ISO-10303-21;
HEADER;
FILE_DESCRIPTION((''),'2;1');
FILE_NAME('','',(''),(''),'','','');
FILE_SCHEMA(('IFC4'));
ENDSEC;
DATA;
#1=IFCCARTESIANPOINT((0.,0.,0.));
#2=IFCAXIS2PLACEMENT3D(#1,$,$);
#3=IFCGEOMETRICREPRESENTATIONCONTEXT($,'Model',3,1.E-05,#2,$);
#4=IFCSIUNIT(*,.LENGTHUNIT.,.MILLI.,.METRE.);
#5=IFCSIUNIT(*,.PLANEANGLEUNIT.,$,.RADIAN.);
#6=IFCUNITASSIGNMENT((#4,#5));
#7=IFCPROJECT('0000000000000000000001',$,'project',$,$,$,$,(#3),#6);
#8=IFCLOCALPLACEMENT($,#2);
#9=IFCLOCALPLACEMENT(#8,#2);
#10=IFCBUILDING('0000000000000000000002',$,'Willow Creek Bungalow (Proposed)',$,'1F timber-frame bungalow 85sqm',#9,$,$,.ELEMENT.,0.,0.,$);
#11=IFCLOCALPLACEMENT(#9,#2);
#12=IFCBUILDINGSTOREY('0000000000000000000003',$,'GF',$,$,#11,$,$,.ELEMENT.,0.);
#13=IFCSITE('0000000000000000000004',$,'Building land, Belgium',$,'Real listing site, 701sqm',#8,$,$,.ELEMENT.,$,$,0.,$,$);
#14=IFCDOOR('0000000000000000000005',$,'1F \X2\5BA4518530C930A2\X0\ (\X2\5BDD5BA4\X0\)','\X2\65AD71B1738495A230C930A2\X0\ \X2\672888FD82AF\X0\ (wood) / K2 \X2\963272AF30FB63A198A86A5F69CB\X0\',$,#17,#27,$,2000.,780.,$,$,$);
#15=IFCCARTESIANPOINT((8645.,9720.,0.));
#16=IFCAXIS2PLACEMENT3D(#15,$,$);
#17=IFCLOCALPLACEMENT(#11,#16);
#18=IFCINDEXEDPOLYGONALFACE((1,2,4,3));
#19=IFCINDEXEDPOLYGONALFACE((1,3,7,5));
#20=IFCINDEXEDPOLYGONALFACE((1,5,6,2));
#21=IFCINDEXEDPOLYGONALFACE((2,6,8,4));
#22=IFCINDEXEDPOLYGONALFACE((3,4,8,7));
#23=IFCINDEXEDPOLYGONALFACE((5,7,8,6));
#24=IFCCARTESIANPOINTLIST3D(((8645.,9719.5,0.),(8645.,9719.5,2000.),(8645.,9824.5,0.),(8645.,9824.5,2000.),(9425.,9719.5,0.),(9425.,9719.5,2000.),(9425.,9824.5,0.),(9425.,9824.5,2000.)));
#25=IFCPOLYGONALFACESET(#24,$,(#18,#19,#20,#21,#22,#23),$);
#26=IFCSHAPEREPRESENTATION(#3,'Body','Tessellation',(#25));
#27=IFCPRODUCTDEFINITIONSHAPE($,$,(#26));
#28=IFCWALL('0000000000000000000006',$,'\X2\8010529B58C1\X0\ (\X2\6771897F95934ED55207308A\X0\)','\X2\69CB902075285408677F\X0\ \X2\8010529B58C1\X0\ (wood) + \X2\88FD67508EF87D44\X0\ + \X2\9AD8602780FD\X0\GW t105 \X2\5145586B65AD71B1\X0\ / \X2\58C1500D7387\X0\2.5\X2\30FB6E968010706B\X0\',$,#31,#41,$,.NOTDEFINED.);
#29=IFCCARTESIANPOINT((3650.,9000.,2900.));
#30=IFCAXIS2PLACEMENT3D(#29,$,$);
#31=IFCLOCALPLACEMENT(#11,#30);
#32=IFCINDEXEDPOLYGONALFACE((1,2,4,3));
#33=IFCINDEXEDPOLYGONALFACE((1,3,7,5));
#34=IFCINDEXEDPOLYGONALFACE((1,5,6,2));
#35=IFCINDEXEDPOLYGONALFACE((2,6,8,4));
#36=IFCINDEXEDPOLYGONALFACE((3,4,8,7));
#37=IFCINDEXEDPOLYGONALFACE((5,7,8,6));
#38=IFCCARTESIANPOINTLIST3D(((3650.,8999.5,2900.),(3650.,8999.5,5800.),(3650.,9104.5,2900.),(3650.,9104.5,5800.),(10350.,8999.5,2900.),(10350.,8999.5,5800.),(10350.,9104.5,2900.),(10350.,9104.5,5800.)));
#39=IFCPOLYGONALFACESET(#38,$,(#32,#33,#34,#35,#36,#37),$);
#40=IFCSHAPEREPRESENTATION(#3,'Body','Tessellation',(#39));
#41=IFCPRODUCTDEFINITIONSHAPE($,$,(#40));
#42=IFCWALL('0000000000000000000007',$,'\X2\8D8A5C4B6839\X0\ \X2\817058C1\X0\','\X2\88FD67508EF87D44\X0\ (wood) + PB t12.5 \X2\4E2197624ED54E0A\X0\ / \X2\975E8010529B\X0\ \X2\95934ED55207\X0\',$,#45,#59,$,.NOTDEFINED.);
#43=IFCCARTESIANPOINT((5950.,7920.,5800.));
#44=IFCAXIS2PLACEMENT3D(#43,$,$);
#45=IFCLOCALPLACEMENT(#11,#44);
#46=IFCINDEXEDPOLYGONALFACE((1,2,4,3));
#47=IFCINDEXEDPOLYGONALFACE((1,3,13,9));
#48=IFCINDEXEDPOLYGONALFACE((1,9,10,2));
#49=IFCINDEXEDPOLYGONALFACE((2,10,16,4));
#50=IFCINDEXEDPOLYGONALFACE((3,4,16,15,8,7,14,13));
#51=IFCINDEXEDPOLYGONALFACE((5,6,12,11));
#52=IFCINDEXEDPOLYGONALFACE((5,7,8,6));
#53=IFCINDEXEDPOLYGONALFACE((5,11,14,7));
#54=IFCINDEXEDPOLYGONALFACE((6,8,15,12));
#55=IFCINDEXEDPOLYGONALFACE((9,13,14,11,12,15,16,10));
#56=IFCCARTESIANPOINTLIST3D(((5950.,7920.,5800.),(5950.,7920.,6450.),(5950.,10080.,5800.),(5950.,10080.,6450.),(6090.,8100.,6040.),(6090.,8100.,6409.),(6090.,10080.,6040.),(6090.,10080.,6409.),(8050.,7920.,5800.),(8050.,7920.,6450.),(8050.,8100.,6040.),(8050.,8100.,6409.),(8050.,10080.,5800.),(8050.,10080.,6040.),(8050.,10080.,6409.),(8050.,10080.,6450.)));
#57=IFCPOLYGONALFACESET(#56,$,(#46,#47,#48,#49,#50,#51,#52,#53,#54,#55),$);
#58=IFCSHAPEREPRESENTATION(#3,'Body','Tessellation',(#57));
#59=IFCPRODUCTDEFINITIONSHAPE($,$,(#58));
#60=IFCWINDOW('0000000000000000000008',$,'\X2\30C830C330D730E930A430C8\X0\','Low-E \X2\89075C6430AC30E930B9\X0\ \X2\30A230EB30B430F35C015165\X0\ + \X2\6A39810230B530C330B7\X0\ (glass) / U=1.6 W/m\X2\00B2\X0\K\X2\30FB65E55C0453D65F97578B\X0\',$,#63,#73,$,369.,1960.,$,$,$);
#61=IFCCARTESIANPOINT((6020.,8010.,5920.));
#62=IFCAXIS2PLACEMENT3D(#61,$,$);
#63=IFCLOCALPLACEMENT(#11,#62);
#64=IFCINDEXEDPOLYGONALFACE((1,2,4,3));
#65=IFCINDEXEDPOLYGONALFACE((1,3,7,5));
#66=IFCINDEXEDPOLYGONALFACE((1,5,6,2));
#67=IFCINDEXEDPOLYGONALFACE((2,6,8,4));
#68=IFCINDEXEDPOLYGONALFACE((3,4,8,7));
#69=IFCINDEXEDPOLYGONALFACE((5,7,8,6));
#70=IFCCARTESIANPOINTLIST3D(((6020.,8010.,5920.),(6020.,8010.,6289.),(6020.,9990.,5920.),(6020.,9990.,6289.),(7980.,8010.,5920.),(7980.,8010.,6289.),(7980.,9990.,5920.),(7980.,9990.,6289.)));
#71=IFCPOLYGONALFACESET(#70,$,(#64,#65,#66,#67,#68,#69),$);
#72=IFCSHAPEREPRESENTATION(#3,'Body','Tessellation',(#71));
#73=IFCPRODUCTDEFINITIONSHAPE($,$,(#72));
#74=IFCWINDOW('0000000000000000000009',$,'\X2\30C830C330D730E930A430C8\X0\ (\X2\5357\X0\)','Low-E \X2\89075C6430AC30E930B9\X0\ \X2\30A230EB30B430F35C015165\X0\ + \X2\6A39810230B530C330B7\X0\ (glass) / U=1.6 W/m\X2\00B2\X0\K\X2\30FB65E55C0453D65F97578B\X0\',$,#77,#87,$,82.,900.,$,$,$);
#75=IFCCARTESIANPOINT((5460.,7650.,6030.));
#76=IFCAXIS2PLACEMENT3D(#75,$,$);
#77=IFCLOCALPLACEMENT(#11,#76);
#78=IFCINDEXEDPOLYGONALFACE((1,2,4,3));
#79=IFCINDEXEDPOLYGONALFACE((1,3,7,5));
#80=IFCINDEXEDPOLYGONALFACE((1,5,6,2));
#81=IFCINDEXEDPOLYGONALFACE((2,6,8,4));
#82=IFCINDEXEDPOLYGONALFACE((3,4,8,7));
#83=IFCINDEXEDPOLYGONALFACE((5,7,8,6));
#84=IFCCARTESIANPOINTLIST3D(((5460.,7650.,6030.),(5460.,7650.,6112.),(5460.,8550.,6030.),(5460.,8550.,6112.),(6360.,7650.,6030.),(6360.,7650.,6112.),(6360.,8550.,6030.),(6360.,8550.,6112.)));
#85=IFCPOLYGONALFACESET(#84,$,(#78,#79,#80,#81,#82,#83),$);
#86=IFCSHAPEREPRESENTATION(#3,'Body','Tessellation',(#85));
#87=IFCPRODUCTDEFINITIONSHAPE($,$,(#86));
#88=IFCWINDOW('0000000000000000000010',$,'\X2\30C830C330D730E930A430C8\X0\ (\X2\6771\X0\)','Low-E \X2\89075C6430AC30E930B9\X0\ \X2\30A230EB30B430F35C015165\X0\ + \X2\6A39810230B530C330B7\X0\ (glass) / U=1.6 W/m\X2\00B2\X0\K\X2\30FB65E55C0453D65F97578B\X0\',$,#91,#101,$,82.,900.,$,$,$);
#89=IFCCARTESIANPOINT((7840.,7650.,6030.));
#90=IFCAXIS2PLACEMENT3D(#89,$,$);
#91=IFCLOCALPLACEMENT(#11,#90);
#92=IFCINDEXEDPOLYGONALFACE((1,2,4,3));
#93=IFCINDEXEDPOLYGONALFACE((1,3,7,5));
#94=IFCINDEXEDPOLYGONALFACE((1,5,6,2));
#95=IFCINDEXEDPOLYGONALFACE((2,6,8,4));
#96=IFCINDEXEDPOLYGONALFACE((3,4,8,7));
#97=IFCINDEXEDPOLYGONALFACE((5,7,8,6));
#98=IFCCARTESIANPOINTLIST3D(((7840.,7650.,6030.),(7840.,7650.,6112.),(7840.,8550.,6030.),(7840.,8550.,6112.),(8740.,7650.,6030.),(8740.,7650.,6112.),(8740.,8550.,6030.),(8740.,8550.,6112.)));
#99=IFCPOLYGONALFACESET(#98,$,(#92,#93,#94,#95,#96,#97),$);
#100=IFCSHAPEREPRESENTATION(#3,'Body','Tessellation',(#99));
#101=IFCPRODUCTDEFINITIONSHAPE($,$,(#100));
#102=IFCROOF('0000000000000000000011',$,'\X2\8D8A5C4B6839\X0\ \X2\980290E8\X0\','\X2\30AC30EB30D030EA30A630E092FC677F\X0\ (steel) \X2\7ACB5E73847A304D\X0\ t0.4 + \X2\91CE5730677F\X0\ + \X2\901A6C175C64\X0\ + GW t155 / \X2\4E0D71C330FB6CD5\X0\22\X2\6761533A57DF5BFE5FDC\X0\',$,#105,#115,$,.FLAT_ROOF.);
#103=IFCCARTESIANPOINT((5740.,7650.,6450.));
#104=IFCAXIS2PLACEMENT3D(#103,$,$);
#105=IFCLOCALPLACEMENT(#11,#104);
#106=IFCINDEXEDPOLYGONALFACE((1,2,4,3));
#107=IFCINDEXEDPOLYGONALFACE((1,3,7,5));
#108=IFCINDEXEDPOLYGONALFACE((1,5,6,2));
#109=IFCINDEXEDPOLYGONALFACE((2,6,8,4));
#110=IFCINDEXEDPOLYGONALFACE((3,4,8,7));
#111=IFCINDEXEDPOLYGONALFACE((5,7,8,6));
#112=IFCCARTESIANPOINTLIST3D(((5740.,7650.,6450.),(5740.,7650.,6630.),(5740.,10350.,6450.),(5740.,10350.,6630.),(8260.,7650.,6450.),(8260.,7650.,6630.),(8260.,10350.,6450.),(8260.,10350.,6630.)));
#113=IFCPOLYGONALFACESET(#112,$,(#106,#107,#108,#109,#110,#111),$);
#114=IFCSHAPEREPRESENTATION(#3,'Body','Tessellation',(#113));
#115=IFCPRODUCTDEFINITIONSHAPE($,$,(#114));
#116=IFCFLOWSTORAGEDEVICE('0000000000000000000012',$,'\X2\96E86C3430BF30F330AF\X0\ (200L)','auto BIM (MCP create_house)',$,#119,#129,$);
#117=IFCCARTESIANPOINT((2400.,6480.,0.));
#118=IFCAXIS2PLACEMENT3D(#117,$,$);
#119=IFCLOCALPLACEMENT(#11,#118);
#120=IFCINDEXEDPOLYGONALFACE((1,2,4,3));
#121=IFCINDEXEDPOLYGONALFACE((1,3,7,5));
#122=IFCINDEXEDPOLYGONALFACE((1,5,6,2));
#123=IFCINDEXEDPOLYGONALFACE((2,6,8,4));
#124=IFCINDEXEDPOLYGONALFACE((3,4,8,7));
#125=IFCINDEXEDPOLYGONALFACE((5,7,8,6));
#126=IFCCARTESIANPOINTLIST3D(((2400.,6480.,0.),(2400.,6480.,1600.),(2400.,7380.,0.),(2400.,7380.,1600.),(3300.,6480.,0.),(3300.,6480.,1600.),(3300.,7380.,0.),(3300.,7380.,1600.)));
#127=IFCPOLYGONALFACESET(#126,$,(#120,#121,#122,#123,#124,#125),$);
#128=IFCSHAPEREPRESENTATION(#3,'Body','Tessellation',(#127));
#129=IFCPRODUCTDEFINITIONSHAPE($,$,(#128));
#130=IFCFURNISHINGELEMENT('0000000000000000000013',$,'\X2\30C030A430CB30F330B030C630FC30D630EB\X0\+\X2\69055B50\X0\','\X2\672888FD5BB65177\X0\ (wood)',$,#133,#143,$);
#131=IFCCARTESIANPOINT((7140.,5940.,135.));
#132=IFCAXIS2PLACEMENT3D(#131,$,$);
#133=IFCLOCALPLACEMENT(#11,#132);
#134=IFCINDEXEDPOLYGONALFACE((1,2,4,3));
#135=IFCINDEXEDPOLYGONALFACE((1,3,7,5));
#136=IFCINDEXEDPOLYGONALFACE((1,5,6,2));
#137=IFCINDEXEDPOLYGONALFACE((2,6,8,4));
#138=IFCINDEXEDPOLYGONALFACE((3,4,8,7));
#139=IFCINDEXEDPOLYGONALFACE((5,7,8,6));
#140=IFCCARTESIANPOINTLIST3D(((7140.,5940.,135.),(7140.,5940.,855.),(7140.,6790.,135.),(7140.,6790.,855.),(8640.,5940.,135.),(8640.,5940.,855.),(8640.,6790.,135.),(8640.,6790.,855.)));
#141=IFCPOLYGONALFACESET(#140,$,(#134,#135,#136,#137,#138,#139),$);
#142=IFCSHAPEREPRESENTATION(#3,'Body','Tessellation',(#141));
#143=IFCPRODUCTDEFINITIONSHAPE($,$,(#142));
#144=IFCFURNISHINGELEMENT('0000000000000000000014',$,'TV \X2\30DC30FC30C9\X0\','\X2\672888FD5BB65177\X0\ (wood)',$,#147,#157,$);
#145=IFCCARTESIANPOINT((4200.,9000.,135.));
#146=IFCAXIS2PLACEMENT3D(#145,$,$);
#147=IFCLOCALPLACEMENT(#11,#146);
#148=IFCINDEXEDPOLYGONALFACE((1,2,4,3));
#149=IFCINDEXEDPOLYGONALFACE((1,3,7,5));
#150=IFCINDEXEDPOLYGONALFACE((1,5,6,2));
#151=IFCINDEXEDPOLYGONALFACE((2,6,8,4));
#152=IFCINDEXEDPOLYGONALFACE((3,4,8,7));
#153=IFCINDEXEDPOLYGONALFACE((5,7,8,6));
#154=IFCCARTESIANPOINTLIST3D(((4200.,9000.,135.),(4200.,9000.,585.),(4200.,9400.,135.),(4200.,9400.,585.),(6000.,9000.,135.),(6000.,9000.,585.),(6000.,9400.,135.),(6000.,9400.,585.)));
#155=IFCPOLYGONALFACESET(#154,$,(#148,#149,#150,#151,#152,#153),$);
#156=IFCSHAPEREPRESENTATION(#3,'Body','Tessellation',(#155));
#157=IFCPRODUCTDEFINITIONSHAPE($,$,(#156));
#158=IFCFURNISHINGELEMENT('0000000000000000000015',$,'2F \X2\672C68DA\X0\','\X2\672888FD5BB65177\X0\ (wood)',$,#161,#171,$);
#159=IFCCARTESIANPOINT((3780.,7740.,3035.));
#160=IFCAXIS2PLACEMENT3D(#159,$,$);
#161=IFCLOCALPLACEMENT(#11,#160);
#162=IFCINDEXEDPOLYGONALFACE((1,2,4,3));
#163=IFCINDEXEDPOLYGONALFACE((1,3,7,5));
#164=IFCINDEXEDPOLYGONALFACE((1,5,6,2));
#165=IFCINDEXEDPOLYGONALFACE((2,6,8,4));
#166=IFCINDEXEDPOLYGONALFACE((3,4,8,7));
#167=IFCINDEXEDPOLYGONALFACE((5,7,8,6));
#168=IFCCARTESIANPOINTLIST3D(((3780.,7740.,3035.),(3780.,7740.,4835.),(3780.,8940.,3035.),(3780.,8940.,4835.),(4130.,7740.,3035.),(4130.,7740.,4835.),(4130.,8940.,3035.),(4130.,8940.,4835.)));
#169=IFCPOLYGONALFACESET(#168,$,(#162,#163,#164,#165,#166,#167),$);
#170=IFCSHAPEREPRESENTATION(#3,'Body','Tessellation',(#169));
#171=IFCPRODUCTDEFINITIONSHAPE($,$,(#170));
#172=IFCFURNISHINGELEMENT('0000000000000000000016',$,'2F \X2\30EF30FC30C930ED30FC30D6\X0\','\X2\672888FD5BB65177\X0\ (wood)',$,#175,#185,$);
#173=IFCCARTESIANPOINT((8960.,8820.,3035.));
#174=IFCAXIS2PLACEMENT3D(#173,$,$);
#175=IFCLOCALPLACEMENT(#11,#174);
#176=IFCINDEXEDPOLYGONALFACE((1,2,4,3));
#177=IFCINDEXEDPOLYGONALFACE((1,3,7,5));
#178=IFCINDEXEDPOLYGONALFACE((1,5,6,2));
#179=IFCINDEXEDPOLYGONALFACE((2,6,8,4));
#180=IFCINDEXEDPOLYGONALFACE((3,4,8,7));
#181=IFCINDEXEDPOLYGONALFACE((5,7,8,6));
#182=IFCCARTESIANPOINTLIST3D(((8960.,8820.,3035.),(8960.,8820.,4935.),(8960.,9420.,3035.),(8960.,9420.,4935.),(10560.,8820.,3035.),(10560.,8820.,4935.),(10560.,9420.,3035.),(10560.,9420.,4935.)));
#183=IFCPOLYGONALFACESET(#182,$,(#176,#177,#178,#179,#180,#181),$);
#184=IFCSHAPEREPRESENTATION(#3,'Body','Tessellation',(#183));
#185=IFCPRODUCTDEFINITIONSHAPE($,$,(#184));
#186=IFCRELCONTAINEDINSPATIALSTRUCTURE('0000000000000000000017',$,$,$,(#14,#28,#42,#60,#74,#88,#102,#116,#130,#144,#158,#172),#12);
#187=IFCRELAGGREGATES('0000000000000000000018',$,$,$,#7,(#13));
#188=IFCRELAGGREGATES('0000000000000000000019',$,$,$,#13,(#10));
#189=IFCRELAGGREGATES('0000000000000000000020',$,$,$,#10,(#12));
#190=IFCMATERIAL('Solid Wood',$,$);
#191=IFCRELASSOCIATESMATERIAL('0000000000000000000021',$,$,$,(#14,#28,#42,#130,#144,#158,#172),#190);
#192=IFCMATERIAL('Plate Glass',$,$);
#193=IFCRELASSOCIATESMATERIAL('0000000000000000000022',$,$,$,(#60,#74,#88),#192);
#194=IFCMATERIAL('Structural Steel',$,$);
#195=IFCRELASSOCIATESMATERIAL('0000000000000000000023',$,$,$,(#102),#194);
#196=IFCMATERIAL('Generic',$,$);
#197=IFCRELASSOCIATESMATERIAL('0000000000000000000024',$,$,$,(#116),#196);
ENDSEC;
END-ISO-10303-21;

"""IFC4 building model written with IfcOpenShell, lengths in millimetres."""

from ifc_helpers import new_model, si_unit, frame, frame_2d, origin, place, context, project, spatial, rectangle, extrude, material, element, fill, save


model = new_model("IFC4")

# Units and contexts
model_context = context("Model", 3, precision=1e-05, world=origin())
ifc_project = project(units=[si_unit("LENGTHUNIT", "METRE", prefix="MILLI"), si_unit("PLANEANGLEUNIT", "RADIAN")], contexts=[model_context])

# Site, building, storey
site_placement = place(None, origin())
site = spatial("IfcSite", under=ifc_project, at=site_placement, Name="Building land, Belgium", ObjectType="Real listing site, 701sqm", CompositionType="ELEMENT", RefElevation=0.0)
building_placement = place(site_placement, origin())
building = spatial("IfcBuilding", under=site, at=building_placement, Name="Willow Creek Bungalow (Proposed)", ObjectType="1F timber-frame bungalow 85sqm", CompositionType="ELEMENT", ElevationOfRefHeight=0.0, ElevationOfTerrain=0.0)
storey_placement = place(building_placement, origin())
storey = spatial("IfcBuildingStorey", under=building, at=storey_placement, Name="GF", CompositionType="ELEMENT", Elevation=0.0)

# Shared definitions
ifc_material_1 = material(Name="Solid Wood")

# Door
door_placement = place(storey_placement, frame((8645.0, 9720.0, 0.0)))
element("IfcDoor", 1, at=door_placement, inside=storey, material=ifc_material_1, Name="1F 室内ドア (寝室)", Description="断熱玄関ドア 木製芯 (wood) / K2 防犯・採風機構", OverallHeight=2000.0, OverallWidth=780.0, context=model_context, shape_type="SweptSolid", body=[
    extrude(rectangle(XDim=780.0, YDim=105.0, at=frame_2d((390.0, 52.0))), frame((8645.0, 9720.0, 0.0)), (0.0, 0.0, 1.0), 2000.0),
])

# Wall
wall_1_placement = place(storey_placement, frame((3650.0, 9000.0, 2900.0)))
element("IfcWall", 2, at=wall_1_placement, inside=storey, material=ifc_material_1, Name="耐力壁 (東西間仕切り)", Description="構造用合板 耐力壁 (wood) + 製材軸組 + 高性能GW t105 充填断熱 / 壁倍率2.5・準耐火", PredefinedType="NOTDEFINED", context=model_context, shape_type="SweptSolid", body=[
    extrude(rectangle(XDim=6700.0, YDim=105.0, at=frame_2d((3350.0, 52.0))), frame((3650.0, 9000.0, 2900.0)), (0.0, 0.0, 1.0), 2900.0),
])

# Wall, openings, windows
wall_2_placement = place(storey_placement, frame((5950.0, 7920.0, 5800.0)))
wall_2 = element("IfcWall", 3, at=wall_2_placement, inside=storey, material=ifc_material_1, Name="越屋根 腰壁", Description="製材軸組 (wood) + PB t12.5 両面仕上 / 非耐力 間仕切", PredefinedType="NOTDEFINED", context=model_context, shape_type="SweptSolid", body=[
    extrude(rectangle(XDim=2100.0, YDim=2160.0, at=frame_2d((1050.0, 1080.0))), frame((5950.0, 7920.0, 5800.0)), (0.0, 0.0, 1.0), 650.0),
])
opening_1_placement = place(storey_placement, frame((6020.0, 8010.0, 5920.0)))
opening_1 = element("IfcOpeningElement", 4, at=opening_1_placement, cuts=wall_2, PredefinedType="NOTDEFINED", context=model_context, shape_type="SweptSolid", body=[
    extrude(rectangle(XDim=1960.0, YDim=1980.0, at=frame_2d((980.0, 990.0))), frame((6020.0, 8010.0, 5920.0)), (0.0, 0.0, 1.0), 369.0),
])
opening_2_placement = place(storey_placement, frame((5460.0, 7650.0, 6030.0)))
opening_2 = element("IfcOpeningElement", 5, at=opening_2_placement, cuts=wall_2, PredefinedType="NOTDEFINED", context=model_context, shape_type="SweptSolid", body=[
    extrude(rectangle(XDim=900.0, YDim=900.0, at=frame_2d((450.0, 450.0))), frame((5460.0, 7650.0, 6030.0)), (0.0, 0.0, 1.0), 82.0),
])
opening_3_placement = place(storey_placement, frame((7840.0, 7650.0, 6030.0)))
opening_3 = element("IfcOpeningElement", 6, at=opening_3_placement, cuts=wall_2, PredefinedType="NOTDEFINED", context=model_context, shape_type="SweptSolid", body=[
    extrude(rectangle(XDim=900.0, YDim=900.0, at=frame_2d((450.0, 450.0))), frame((7840.0, 7650.0, 6030.0)), (0.0, 0.0, 1.0), 82.0),
])
ifc_material_2 = material(Name="Plate Glass")
window_1_placement = place(storey_placement, frame((6020.0, 8010.0, 5920.0)))
window_1 = element("IfcWindow", 7, at=window_1_placement, inside=storey, material=ifc_material_2, Name="トップライト", Description="Low-E 複層ガラス アルゴン封入 + 樹脂サッシ (glass) / U=1.6 W/m²K・日射取得型", OverallHeight=369.0, OverallWidth=1960.0, context=model_context, shape_type="SweptSolid", body=[
    extrude(rectangle(XDim=1960.0, YDim=1980.0, at=frame_2d((980.0, 990.0))), frame((6020.0, 8010.0, 5920.0)), (0.0, 0.0, 1.0), 369.0),
])
fill(opening_1, window_1)
window_2_placement = place(storey_placement, frame((5460.0, 7650.0, 6030.0)))
window_2 = element("IfcWindow", 8, at=window_2_placement, inside=storey, material=ifc_material_2, Name="トップライト (南)", Description="Low-E 複層ガラス アルゴン封入 + 樹脂サッシ (glass) / U=1.6 W/m²K・日射取得型", OverallHeight=82.0, OverallWidth=900.0, context=model_context, shape_type="SweptSolid", body=[
    extrude(rectangle(XDim=900.0, YDim=900.0, at=frame_2d((450.0, 450.0))), frame((5460.0, 7650.0, 6030.0)), (0.0, 0.0, 1.0), 82.0),
])
fill(opening_2, window_2)
window_3_placement = place(storey_placement, frame((7840.0, 7650.0, 6030.0)))
window_3 = element("IfcWindow", 9, at=window_3_placement, inside=storey, material=ifc_material_2, Name="トップライト (東)", Description="Low-E 複層ガラス アルゴン封入 + 樹脂サッシ (glass) / U=1.6 W/m²K・日射取得型", OverallHeight=82.0, OverallWidth=900.0, context=model_context, shape_type="SweptSolid", body=[
    extrude(rectangle(XDim=900.0, YDim=900.0, at=frame_2d((450.0, 450.0))), frame((7840.0, 7650.0, 6030.0)), (0.0, 0.0, 1.0), 82.0),
])
fill(opening_3, window_3)

# Roof
ifc_material_3 = material(Name="Structural Steel")
roof_placement = place(storey_placement, frame((5740.0, 7650.0, 6450.0)))
element("IfcRoof", 10, at=roof_placement, inside=storey, material=ifc_material_3, Name="越屋根 頂部", Description="ガルバリウム鋼板 (steel) 立平葺き t0.4 + 野地板 + 通気層 + GW t155 / 不燃・法22条区域対応", PredefinedType="FLAT_ROOF", context=model_context, shape_type="SweptSolid", body=[
    extrude(rectangle(XDim=2520.0, YDim=2700.0, at=frame_2d((1260.0, 1350.0))), frame((5740.0, 7650.0, 6450.0)), (0.0, 0.0, 1.0), 180.0),
])

# Flow storage device
ifc_material_4 = material(Name="Generic")
flow_storage_device_placement = place(storey_placement, frame((2400.0, 6480.0, 0.0)))
element("IfcFlowStorageDevice", 11, at=flow_storage_device_placement, inside=storey, material=ifc_material_4, Name="雨水タンク (200L)", Description="auto BIM (MCP create_house)", context=model_context, shape_type="SweptSolid", body=[
    extrude(rectangle(XDim=900.0, YDim=900.0, at=frame_2d((450.0, 450.0))), frame((2400.0, 6480.0, 0.0)), (0.0, 0.0, 1.0), 1600.0),
])

# Furnishing elements
furnishing_1_placement = place(storey_placement, frame((7140.0, 5940.0, 135.0)))
element("IfcFurnishingElement", 12, at=furnishing_1_placement, inside=storey, material=ifc_material_1, Name="ダイニングテーブル+椅子", Description="木製家具 (wood)", context=model_context, shape_type="SweptSolid", body=[
    extrude(rectangle(XDim=1500.0, YDim=850.0, at=frame_2d((750.0, 425.0))), frame((7140.0, 5940.0, 135.0)), (0.0, 0.0, 1.0), 720.0),
])
furnishing_2_placement = place(storey_placement, frame((4200.0, 9000.0, 135.0)))
element("IfcFurnishingElement", 13, at=furnishing_2_placement, inside=storey, material=ifc_material_1, Name="TV ボード", Description="木製家具 (wood)", context=model_context, shape_type="SweptSolid", body=[
    extrude(rectangle(XDim=1800.0, YDim=400.0, at=frame_2d((900.0, 200.0))), frame((4200.0, 9000.0, 135.0)), (0.0, 0.0, 1.0), 450.0),
])
furnishing_3_placement = place(storey_placement, frame((3780.0, 7740.0, 3035.0)))
element("IfcFurnishingElement", 14, at=furnishing_3_placement, inside=storey, material=ifc_material_1, Name="2F 本棚", Description="木製家具 (wood)", context=model_context, shape_type="SweptSolid", body=[
    extrude(rectangle(XDim=350.0, YDim=1200.0, at=frame_2d((175.0, 600.0))), frame((3780.0, 7740.0, 3035.0)), (0.0, 0.0, 1.0), 1800.0),
])
furnishing_4_placement = place(storey_placement, frame((8960.0, 8820.0, 3035.0)))
element("IfcFurnishingElement", 15, at=furnishing_4_placement, inside=storey, material=ifc_material_1, Name="2F ワードローブ", Description="木製家具 (wood)", context=model_context, shape_type="SweptSolid", body=[
    extrude(rectangle(XDim=1600.0, YDim=600.0, at=frame_2d((800.0, 300.0))), frame((8960.0, 8820.0, 3035.0)), (0.0, 0.0, 1.0), 1900.0),
])

save(model, "model.ifc")
